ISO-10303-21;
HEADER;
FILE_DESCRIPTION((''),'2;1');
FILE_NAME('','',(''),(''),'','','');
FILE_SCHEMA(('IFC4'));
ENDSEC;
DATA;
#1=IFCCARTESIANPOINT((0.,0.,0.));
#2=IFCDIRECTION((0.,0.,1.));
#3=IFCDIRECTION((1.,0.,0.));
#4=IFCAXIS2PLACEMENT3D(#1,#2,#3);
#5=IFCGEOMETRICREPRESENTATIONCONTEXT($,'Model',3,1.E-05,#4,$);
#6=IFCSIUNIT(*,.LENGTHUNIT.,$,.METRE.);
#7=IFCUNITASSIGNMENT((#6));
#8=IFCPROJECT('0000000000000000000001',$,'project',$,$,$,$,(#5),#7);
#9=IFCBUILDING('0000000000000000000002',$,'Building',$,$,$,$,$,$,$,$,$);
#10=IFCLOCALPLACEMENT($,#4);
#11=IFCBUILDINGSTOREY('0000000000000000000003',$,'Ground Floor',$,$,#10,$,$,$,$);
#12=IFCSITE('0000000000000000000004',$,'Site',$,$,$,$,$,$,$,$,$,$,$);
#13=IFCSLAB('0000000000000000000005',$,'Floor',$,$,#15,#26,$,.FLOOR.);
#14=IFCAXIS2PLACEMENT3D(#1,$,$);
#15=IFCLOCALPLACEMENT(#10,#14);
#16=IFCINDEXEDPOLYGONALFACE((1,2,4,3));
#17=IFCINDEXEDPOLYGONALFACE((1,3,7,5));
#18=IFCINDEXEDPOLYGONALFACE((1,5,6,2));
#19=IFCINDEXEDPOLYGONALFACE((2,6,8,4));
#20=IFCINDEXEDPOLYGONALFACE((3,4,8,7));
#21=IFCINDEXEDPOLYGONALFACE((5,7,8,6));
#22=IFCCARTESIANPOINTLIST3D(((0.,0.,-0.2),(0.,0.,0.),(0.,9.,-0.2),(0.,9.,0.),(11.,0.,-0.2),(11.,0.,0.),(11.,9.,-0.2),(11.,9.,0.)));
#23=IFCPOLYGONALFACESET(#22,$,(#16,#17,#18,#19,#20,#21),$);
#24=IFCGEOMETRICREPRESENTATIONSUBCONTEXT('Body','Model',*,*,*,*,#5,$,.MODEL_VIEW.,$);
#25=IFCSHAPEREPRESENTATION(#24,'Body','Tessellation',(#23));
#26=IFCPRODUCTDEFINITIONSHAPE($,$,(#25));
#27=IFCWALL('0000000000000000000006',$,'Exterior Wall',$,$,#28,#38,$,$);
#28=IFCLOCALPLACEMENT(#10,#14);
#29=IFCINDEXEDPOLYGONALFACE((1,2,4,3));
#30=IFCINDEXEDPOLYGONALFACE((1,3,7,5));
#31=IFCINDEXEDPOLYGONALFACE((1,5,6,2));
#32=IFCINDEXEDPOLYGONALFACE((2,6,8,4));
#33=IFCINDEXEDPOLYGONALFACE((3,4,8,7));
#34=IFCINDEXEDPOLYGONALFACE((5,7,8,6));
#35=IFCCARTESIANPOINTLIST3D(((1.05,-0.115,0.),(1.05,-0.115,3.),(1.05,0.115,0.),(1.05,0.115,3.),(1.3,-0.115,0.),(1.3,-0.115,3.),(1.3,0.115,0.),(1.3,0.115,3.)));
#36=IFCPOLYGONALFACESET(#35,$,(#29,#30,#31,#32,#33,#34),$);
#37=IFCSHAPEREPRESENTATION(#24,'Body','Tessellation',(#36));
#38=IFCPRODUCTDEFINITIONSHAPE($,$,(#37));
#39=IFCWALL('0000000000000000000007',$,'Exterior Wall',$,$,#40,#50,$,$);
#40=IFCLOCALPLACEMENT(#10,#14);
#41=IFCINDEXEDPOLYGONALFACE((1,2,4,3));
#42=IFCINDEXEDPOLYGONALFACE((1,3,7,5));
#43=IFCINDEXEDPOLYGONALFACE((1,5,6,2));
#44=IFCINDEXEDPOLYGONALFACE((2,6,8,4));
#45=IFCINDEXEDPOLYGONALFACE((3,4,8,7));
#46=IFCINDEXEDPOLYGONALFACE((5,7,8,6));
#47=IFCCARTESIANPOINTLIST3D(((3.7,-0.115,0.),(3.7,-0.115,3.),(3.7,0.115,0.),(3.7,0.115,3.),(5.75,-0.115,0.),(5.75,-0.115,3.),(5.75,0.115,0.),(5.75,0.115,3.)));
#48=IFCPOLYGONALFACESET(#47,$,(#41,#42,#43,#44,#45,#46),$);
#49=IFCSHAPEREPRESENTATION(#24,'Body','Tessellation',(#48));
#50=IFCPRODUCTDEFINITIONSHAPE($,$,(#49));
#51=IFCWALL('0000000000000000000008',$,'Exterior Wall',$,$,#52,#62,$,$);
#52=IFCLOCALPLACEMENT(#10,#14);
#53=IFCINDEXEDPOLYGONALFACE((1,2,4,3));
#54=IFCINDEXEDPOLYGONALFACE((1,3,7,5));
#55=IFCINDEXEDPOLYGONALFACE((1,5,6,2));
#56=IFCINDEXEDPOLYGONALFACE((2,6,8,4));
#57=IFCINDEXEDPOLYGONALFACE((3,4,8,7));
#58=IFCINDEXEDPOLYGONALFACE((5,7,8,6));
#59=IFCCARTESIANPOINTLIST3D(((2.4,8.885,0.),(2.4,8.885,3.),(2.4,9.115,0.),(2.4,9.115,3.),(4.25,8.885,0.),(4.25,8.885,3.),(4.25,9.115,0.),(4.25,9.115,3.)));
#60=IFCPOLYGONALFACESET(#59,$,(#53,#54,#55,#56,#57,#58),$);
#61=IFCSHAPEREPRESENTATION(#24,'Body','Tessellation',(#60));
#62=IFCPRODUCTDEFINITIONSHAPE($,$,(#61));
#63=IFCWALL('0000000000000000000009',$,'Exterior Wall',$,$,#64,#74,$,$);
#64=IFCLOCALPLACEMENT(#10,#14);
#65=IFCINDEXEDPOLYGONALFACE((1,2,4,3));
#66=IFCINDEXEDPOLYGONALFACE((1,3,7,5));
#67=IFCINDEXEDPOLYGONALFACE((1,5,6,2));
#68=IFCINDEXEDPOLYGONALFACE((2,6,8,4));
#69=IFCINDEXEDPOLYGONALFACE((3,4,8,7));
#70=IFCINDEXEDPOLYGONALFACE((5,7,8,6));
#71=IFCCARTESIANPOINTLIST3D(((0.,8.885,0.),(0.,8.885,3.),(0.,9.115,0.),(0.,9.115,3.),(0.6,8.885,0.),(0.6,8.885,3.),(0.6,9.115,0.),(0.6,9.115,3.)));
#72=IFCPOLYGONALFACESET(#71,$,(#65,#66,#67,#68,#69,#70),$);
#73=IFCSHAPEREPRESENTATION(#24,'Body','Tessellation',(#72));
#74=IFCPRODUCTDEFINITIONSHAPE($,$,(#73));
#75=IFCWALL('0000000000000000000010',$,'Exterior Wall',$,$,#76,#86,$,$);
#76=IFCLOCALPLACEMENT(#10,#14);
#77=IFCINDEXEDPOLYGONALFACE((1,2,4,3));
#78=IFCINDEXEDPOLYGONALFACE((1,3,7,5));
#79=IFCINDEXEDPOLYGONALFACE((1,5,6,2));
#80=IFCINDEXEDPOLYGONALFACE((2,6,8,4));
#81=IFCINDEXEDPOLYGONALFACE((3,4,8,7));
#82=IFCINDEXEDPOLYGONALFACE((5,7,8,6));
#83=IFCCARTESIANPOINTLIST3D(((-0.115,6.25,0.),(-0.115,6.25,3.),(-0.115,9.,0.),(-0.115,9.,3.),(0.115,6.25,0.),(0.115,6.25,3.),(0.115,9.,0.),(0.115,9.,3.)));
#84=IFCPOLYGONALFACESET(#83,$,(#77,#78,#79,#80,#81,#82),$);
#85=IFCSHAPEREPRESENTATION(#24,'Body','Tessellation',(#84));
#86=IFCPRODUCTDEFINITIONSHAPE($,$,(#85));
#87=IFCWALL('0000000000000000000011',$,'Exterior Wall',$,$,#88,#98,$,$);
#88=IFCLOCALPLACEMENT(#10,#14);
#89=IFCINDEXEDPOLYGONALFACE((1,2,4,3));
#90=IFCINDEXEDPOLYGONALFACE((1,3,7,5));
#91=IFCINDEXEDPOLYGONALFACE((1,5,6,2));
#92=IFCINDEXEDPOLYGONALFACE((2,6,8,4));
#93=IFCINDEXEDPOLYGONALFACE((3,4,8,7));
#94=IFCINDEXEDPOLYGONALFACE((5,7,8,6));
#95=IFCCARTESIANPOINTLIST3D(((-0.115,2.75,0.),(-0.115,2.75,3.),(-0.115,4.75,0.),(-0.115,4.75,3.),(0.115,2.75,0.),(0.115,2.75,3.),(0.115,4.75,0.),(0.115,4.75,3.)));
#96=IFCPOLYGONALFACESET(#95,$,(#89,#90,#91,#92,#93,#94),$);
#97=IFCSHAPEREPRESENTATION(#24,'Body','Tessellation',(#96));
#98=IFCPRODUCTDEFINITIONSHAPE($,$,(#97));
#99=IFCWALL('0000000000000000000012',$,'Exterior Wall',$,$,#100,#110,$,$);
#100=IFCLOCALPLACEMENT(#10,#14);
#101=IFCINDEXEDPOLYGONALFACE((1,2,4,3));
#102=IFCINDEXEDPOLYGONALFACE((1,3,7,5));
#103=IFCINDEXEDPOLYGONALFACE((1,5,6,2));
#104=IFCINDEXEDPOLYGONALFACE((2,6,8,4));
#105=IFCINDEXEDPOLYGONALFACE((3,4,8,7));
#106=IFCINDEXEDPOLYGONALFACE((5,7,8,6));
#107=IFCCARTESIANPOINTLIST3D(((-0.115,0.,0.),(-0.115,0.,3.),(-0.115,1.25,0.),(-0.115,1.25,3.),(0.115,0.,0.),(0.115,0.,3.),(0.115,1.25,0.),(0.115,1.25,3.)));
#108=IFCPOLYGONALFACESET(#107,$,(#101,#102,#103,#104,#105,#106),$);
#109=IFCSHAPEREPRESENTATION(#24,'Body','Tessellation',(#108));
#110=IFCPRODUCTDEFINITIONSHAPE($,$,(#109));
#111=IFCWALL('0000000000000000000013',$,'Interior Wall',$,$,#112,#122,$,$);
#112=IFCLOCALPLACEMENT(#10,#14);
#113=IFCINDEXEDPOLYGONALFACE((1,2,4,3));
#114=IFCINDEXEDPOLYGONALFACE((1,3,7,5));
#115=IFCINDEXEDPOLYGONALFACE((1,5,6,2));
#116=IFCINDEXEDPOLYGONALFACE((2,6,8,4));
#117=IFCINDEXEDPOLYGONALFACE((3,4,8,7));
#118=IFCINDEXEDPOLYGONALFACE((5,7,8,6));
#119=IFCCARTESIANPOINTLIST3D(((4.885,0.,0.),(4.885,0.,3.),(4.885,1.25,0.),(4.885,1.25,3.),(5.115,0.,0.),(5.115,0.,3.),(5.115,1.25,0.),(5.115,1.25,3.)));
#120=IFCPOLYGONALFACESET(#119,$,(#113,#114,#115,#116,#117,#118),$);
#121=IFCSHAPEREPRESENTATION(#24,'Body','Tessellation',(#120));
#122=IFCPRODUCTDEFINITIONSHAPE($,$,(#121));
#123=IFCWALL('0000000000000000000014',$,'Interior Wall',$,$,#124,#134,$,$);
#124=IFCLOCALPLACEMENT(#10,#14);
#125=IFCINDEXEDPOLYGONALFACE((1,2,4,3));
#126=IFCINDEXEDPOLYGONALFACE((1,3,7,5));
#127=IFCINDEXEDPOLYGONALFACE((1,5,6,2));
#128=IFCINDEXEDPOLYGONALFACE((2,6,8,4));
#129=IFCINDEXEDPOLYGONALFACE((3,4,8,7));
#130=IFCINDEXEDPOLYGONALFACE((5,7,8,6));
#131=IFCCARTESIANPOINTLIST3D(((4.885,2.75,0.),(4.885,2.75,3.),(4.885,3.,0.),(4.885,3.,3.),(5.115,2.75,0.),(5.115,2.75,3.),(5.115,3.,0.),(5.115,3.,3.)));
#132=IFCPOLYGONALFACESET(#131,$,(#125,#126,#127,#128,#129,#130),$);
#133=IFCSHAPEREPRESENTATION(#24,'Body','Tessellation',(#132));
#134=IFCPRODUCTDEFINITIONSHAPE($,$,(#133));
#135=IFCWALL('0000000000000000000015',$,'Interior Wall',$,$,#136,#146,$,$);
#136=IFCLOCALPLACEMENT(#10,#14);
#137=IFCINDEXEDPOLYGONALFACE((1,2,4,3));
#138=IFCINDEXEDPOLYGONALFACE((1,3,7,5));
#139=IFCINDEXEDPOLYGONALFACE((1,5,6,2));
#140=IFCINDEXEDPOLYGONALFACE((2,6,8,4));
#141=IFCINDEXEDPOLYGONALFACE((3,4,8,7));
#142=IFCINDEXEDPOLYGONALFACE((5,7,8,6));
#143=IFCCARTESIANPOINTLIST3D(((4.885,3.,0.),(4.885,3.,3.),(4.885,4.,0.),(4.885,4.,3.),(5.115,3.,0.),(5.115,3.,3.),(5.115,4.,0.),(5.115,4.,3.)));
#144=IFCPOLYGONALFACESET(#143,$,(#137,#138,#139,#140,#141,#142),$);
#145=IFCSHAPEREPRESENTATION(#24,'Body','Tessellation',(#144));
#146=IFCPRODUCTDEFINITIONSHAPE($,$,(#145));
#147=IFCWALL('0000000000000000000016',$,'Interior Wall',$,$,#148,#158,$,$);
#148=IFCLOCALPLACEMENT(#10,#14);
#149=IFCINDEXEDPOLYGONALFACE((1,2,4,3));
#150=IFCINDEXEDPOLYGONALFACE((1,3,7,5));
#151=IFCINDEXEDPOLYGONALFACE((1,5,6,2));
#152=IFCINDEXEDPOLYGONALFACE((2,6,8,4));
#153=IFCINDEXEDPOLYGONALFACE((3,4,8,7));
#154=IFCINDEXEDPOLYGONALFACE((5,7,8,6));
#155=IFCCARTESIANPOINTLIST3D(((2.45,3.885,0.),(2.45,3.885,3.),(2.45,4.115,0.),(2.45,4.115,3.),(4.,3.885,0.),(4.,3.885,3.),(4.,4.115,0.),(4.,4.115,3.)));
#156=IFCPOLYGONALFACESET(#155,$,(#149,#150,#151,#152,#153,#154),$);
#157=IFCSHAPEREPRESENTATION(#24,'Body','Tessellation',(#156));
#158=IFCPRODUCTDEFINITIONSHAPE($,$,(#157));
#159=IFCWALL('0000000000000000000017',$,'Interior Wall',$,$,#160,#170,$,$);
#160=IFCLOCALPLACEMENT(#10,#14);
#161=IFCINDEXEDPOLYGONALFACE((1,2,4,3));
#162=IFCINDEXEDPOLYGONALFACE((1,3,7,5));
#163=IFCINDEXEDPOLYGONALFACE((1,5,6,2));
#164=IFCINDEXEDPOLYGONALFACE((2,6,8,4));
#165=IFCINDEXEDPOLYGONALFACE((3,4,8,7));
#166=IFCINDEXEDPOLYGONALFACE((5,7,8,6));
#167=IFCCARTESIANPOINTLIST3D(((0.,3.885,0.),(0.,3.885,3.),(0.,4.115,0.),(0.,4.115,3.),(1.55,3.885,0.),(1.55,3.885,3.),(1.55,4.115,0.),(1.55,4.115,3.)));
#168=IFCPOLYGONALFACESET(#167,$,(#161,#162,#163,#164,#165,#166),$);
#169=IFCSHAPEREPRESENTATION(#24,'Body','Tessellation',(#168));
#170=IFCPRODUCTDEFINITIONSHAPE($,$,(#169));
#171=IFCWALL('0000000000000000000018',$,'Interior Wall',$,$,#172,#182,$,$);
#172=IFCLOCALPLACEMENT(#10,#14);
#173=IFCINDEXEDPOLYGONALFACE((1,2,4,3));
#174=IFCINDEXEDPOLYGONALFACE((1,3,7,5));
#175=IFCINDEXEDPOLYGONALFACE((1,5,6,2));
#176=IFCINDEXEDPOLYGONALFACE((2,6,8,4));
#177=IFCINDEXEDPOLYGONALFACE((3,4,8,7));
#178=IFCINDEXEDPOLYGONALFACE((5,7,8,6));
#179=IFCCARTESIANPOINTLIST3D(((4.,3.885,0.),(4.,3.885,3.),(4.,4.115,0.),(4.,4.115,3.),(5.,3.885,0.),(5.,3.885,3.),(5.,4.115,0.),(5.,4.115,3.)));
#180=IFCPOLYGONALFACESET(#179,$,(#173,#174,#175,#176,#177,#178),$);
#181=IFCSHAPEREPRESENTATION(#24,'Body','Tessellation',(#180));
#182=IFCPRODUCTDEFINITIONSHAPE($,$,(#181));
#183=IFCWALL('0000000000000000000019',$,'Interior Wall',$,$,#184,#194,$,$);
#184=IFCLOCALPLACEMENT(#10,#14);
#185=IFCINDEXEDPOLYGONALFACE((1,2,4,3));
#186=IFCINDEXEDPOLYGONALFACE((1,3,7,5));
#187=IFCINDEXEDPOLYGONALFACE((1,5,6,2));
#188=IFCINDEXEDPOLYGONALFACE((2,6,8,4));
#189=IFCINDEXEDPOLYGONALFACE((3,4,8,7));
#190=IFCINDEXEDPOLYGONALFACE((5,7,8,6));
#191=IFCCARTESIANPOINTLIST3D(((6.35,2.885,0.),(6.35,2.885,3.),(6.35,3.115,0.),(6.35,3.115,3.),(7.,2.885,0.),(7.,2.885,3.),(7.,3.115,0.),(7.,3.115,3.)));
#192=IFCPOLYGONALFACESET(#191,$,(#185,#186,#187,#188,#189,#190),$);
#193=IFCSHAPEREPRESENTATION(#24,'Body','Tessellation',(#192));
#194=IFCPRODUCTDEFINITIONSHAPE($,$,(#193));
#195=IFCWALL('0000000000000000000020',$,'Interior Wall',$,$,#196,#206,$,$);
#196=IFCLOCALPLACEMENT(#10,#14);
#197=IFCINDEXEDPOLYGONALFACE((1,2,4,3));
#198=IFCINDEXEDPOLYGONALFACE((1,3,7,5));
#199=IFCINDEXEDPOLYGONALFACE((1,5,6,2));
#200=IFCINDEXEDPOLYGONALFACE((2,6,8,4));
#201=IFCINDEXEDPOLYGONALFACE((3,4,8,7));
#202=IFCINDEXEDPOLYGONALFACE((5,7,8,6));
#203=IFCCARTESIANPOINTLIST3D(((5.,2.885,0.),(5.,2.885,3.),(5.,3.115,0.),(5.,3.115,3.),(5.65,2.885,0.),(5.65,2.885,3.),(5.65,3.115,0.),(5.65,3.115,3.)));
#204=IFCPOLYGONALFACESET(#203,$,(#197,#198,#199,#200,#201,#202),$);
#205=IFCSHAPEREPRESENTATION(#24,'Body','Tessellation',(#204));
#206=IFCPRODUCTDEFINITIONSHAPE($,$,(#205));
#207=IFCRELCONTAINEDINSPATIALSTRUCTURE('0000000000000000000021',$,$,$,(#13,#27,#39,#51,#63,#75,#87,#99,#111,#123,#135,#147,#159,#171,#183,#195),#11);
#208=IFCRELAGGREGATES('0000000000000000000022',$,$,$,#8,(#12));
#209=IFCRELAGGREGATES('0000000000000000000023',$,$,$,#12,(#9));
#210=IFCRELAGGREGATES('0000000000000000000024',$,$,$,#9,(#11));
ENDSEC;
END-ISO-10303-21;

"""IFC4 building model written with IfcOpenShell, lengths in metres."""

from ifc_helpers import new_model, si_unit, frame, origin_with_axes, place, context, subcontext, project, spatial, indexed_curve, outline, extrude, element, save


model = new_model("IFC4")

# Units and contexts
model_context = context("Model", 3, precision=1e-05, world=origin_with_axes())
body_context = subcontext(model_context, "Body", "Model", "MODEL_VIEW")
ifc_project = project(units=[si_unit("LENGTHUNIT", "METRE")], contexts=[model_context])

# Site, building, storey
site = spatial("IfcSite", under=ifc_project, Name="Site")
building = spatial("IfcBuilding", under=site, Name="Building")
storey_placement = place(None, origin_with_axes())
storey = spatial("IfcBuildingStorey", under=building, at=storey_placement, Name="Ground Floor")

# Slab
slab_placement = place(storey_placement, frame((0.0, 0.0, -0.2), z_axis=(0.0, 0.0, 1.0), x_axis=(1.0, 0.0, 0.0)))
element("IfcSlab", 1, at=slab_placement, inside=storey, Name="Floor", PredefinedType="FLOOR", context=body_context, shape_type="SweptSolid", body=[
    extrude(outline(indexed_curve([(0.0, 0.0), (11.0, 0.0), (11.0, 9.0), (0.0, 9.0)])), None, (0.0, 0.0, 1.0), 0.2),
])

# Walls
wall_1_placement = place(storey_placement, frame((1.05, 0.0, 0.0), z_axis=(0.0, 0.0, 1.0), x_axis=(1.0, 0.0, 0.0)))
element("IfcWall", 2, at=wall_1_placement, inside=storey, Name="Exterior Wall", context=body_context, shape_type="SweptSolid", body=[
    extrude(outline(indexed_curve([(0.0, 0.0), (0.0, 0.23), (0.25, 0.23), (0.25, 0.0), (0.0, 0.0)], self_intersect=False)), frame((0.0, -0.115, 0.0), z_axis=(0.0, 0.0, 1.0), x_axis=(1.0, 0.0, 0.0)), (0.0, 0.0, 1.0), 3.0),
])
wall_2_placement = place(storey_placement, frame((3.7, 0.0, 0.0), z_axis=(0.0, 0.0, 1.0), x_axis=(1.0, 0.0, 0.0)))
element("IfcWall", 3, at=wall_2_placement, inside=storey, Name="Exterior Wall", context=body_context, shape_type="SweptSolid", body=[
    extrude(outline(indexed_curve([(0.0, 0.0), (0.0, 0.23), (2.05, 0.23), (2.05, 0.0), (0.0, 0.0)], self_intersect=False)), frame((0.0, -0.115, 0.0), z_axis=(0.0, 0.0, 1.0), x_axis=(1.0, 0.0, 0.0)), (0.0, 0.0, 1.0), 3.0),
])
wall_3_placement = place(storey_placement, frame((4.25, 9.0, 0.0), z_axis=(0.0, 0.0, 1.0), x_axis=(-1.0, 0.0, 0.0)))
element("IfcWall", 4, at=wall_3_placement, inside=storey, Name="Exterior Wall", context=body_context, shape_type="SweptSolid", body=[
    extrude(outline(indexed_curve([(0.0, 0.0), (0.0, 0.23), (1.85, 0.23), (1.85, 0.0), (0.0, 0.0)], self_intersect=False)), frame((0.0, -0.115, 0.0), z_axis=(0.0, 0.0, 1.0), x_axis=(1.0, 0.0, 0.0)), (0.0, 0.0, 1.0), 3.0),
])
wall_4_placement = place(storey_placement, frame((0.6, 9.0, 0.0), z_axis=(0.0, 0.0, 1.0), x_axis=(-1.0, 0.0, 0.0)))
element("IfcWall", 5, at=wall_4_placement, inside=storey, Name="Exterior Wall", context=body_context, shape_type="SweptSolid", body=[
    extrude(outline(indexed_curve([(0.0, 0.0), (0.0, 0.23), (0.6, 0.23), (0.6, 0.0), (0.0, 0.0)], self_intersect=False)), frame((0.0, -0.115, 0.0), z_axis=(0.0, 0.0, 1.0), x_axis=(1.0, 0.0, 0.0)), (0.0, 0.0, 1.0), 3.0),
])
wall_5_placement = place(storey_placement, frame((0.0, 9.0, 0.0), z_axis=(0.0, 0.0, 1.0), x_axis=(0.0, -1.0, 0.0)))
element("IfcWall", 6, at=wall_5_placement, inside=storey, Name="Exterior Wall", context=body_context, shape_type="SweptSolid", body=[
    extrude(outline(indexed_curve([(0.0, 0.0), (0.0, 0.23), (2.75, 0.23), (2.75, 0.0), (0.0, 0.0)], self_intersect=False)), frame((0.0, -0.115, 0.0), z_axis=(0.0, 0.0, 1.0), x_axis=(1.0, 0.0, 0.0)), (0.0, 0.0, 1.0), 3.0),
])
wall_6_placement = place(storey_placement, frame((0.0, 4.75, 0.0), z_axis=(0.0, 0.0, 1.0), x_axis=(0.0, -1.0, 0.0)))
element("IfcWall", 7, at=wall_6_placement, inside=storey, Name="Exterior Wall", context=body_context, shape_type="SweptSolid", body=[
    extrude(outline(indexed_curve([(0.0, 0.0), (0.0, 0.23), (2.0, 0.23), (2.0, 0.0), (0.0, 0.0)], self_intersect=False)), frame((0.0, -0.115, 0.0), z_axis=(0.0, 0.0, 1.0), x_axis=(1.0, 0.0, 0.0)), (0.0, 0.0, 1.0), 3.0),
])
for number, where, z_axis, x_axis, name in (
    (8, (0.0, 1.25, 0.0), (0.0, 0.0, 1.0), (0.0, -1.0, 0.0), "Exterior Wall"),
    (9, (5.0, 0.0, 0.0), (0.0, 0.0, 1.0), (0.0, 1.0, 0.0), "Interior Wall"),
):
    element("IfcWall", number, at=place(storey_placement, frame(where, z_axis=z_axis, x_axis=x_axis)), inside=storey, Name=name, context=body_context, shape_type="SweptSolid", body=[
        extrude(outline(indexed_curve([(0.0, 0.0), (0.0, 0.23), (1.25, 0.23), (1.25, 0.0), (0.0, 0.0)], self_intersect=False)), frame((0.0, -0.115, 0.0), z_axis=(0.0, 0.0, 1.0), x_axis=(1.0, 0.0, 0.0)), (0.0, 0.0, 1.0), 3.0),
    ])
wall_7_placement = place(storey_placement, frame((5.0, 2.75, 0.0), z_axis=(0.0, 0.0, 1.0), x_axis=(0.0, 1.0, 0.0)))
element("IfcWall", 10, at=wall_7_placement, inside=storey, Name="Interior Wall", context=body_context, shape_type="SweptSolid", body=[
    extrude(outline(indexed_curve([(0.0, 0.0), (0.0, 0.23), (0.25, 0.23), (0.25, 0.0), (0.0, 0.0)], self_intersect=False)), frame((0.0, -0.115, 0.0), z_axis=(0.0, 0.0, 1.0), x_axis=(1.0, 0.0, 0.0)), (0.0, 0.0, 1.0), 3.0),
])
wall_8_placement = place(storey_placement, frame((5.0, 3.0, 0.0), z_axis=(0.0, 0.0, 1.0), x_axis=(0.0, 1.0, 0.0)))
element("IfcWall", 11, at=wall_8_placement, inside=storey, Name="Interior Wall", context=body_context, shape_type="SweptSolid", body=[
    extrude(outline(indexed_curve([(0.0, 0.0), (0.0, 0.23), (1.0, 0.23), (1.0, 0.0), (0.0, 0.0)], self_intersect=False)), frame((0.0, -0.115, 0.0), z_axis=(0.0, 0.0, 1.0), x_axis=(1.0, 0.0, 0.0)), (0.0, 0.0, 1.0), 3.0),
])
for number, where, z_axis, x_axis, name in (
    (12, (4.0, 4.0, 0.0), (0.0, 0.0, 1.0), (-1.0, 0.0, 0.0), "Interior Wall"),
    (13, (1.55, 4.0, 0.0), (0.0, 0.0, 1.0), (-1.0, 0.0, 0.0), "Interior Wall"),
):
    element("IfcWall", number, at=place(storey_placement, frame(where, z_axis=z_axis, x_axis=x_axis)), inside=storey, Name=name, context=body_context, shape_type="SweptSolid", body=[
        extrude(outline(indexed_curve([(0.0, 0.0), (0.0, 0.23), (1.55, 0.23), (1.55, 0.0), (0.0, 0.0)], self_intersect=False)), frame((0.0, -0.115, 0.0), z_axis=(0.0, 0.0, 1.0), x_axis=(1.0, 0.0, 0.0)), (0.0, 0.0, 1.0), 3.0),
    ])
wall_9_placement = place(storey_placement, frame((5.0, 4.0, 0.0), z_axis=(0.0, 0.0, 1.0), x_axis=(-1.0, 0.0, 0.0)))
element("IfcWall", 14, at=wall_9_placement, inside=storey, Name="Interior Wall", context=body_context, shape_type="SweptSolid", body=[
    extrude(outline(indexed_curve([(0.0, 0.0), (0.0, 0.23), (1.0, 0.23), (1.0, 0.0), (0.0, 0.0)], self_intersect=False)), frame((0.0, -0.115, 0.0), z_axis=(0.0, 0.0, 1.0), x_axis=(1.0, 0.0, 0.0)), (0.0, 0.0, 1.0), 3.0),
])
for number, where, z_axis, x_axis, name in (
    (15, (7.0, 3.0, 0.0), (0.0, 0.0, 1.0), (-1.0, 0.0, 0.0), "Interior Wall"),
    (16, (5.65, 3.0, 0.0), (0.0, 0.0, 1.0), (-1.0, 0.0, 0.0), "Interior Wall"),
):
    element("IfcWall", number, at=place(storey_placement, frame(where, z_axis=z_axis, x_axis=x_axis)), inside=storey, Name=name, context=body_context, shape_type="SweptSolid", body=[
        extrude(outline(indexed_curve([(0.0, 0.0), (0.0, 0.23), (0.65, 0.23), (0.65, 0.0), (0.0, 0.0)], self_intersect=False)), frame((0.0, -0.115, 0.0), z_axis=(0.0, 0.0, 1.0), x_axis=(1.0, 0.0, 0.0)), (0.0, 0.0, 1.0), 3.0),
    ])

save(model, "model.ifc")
